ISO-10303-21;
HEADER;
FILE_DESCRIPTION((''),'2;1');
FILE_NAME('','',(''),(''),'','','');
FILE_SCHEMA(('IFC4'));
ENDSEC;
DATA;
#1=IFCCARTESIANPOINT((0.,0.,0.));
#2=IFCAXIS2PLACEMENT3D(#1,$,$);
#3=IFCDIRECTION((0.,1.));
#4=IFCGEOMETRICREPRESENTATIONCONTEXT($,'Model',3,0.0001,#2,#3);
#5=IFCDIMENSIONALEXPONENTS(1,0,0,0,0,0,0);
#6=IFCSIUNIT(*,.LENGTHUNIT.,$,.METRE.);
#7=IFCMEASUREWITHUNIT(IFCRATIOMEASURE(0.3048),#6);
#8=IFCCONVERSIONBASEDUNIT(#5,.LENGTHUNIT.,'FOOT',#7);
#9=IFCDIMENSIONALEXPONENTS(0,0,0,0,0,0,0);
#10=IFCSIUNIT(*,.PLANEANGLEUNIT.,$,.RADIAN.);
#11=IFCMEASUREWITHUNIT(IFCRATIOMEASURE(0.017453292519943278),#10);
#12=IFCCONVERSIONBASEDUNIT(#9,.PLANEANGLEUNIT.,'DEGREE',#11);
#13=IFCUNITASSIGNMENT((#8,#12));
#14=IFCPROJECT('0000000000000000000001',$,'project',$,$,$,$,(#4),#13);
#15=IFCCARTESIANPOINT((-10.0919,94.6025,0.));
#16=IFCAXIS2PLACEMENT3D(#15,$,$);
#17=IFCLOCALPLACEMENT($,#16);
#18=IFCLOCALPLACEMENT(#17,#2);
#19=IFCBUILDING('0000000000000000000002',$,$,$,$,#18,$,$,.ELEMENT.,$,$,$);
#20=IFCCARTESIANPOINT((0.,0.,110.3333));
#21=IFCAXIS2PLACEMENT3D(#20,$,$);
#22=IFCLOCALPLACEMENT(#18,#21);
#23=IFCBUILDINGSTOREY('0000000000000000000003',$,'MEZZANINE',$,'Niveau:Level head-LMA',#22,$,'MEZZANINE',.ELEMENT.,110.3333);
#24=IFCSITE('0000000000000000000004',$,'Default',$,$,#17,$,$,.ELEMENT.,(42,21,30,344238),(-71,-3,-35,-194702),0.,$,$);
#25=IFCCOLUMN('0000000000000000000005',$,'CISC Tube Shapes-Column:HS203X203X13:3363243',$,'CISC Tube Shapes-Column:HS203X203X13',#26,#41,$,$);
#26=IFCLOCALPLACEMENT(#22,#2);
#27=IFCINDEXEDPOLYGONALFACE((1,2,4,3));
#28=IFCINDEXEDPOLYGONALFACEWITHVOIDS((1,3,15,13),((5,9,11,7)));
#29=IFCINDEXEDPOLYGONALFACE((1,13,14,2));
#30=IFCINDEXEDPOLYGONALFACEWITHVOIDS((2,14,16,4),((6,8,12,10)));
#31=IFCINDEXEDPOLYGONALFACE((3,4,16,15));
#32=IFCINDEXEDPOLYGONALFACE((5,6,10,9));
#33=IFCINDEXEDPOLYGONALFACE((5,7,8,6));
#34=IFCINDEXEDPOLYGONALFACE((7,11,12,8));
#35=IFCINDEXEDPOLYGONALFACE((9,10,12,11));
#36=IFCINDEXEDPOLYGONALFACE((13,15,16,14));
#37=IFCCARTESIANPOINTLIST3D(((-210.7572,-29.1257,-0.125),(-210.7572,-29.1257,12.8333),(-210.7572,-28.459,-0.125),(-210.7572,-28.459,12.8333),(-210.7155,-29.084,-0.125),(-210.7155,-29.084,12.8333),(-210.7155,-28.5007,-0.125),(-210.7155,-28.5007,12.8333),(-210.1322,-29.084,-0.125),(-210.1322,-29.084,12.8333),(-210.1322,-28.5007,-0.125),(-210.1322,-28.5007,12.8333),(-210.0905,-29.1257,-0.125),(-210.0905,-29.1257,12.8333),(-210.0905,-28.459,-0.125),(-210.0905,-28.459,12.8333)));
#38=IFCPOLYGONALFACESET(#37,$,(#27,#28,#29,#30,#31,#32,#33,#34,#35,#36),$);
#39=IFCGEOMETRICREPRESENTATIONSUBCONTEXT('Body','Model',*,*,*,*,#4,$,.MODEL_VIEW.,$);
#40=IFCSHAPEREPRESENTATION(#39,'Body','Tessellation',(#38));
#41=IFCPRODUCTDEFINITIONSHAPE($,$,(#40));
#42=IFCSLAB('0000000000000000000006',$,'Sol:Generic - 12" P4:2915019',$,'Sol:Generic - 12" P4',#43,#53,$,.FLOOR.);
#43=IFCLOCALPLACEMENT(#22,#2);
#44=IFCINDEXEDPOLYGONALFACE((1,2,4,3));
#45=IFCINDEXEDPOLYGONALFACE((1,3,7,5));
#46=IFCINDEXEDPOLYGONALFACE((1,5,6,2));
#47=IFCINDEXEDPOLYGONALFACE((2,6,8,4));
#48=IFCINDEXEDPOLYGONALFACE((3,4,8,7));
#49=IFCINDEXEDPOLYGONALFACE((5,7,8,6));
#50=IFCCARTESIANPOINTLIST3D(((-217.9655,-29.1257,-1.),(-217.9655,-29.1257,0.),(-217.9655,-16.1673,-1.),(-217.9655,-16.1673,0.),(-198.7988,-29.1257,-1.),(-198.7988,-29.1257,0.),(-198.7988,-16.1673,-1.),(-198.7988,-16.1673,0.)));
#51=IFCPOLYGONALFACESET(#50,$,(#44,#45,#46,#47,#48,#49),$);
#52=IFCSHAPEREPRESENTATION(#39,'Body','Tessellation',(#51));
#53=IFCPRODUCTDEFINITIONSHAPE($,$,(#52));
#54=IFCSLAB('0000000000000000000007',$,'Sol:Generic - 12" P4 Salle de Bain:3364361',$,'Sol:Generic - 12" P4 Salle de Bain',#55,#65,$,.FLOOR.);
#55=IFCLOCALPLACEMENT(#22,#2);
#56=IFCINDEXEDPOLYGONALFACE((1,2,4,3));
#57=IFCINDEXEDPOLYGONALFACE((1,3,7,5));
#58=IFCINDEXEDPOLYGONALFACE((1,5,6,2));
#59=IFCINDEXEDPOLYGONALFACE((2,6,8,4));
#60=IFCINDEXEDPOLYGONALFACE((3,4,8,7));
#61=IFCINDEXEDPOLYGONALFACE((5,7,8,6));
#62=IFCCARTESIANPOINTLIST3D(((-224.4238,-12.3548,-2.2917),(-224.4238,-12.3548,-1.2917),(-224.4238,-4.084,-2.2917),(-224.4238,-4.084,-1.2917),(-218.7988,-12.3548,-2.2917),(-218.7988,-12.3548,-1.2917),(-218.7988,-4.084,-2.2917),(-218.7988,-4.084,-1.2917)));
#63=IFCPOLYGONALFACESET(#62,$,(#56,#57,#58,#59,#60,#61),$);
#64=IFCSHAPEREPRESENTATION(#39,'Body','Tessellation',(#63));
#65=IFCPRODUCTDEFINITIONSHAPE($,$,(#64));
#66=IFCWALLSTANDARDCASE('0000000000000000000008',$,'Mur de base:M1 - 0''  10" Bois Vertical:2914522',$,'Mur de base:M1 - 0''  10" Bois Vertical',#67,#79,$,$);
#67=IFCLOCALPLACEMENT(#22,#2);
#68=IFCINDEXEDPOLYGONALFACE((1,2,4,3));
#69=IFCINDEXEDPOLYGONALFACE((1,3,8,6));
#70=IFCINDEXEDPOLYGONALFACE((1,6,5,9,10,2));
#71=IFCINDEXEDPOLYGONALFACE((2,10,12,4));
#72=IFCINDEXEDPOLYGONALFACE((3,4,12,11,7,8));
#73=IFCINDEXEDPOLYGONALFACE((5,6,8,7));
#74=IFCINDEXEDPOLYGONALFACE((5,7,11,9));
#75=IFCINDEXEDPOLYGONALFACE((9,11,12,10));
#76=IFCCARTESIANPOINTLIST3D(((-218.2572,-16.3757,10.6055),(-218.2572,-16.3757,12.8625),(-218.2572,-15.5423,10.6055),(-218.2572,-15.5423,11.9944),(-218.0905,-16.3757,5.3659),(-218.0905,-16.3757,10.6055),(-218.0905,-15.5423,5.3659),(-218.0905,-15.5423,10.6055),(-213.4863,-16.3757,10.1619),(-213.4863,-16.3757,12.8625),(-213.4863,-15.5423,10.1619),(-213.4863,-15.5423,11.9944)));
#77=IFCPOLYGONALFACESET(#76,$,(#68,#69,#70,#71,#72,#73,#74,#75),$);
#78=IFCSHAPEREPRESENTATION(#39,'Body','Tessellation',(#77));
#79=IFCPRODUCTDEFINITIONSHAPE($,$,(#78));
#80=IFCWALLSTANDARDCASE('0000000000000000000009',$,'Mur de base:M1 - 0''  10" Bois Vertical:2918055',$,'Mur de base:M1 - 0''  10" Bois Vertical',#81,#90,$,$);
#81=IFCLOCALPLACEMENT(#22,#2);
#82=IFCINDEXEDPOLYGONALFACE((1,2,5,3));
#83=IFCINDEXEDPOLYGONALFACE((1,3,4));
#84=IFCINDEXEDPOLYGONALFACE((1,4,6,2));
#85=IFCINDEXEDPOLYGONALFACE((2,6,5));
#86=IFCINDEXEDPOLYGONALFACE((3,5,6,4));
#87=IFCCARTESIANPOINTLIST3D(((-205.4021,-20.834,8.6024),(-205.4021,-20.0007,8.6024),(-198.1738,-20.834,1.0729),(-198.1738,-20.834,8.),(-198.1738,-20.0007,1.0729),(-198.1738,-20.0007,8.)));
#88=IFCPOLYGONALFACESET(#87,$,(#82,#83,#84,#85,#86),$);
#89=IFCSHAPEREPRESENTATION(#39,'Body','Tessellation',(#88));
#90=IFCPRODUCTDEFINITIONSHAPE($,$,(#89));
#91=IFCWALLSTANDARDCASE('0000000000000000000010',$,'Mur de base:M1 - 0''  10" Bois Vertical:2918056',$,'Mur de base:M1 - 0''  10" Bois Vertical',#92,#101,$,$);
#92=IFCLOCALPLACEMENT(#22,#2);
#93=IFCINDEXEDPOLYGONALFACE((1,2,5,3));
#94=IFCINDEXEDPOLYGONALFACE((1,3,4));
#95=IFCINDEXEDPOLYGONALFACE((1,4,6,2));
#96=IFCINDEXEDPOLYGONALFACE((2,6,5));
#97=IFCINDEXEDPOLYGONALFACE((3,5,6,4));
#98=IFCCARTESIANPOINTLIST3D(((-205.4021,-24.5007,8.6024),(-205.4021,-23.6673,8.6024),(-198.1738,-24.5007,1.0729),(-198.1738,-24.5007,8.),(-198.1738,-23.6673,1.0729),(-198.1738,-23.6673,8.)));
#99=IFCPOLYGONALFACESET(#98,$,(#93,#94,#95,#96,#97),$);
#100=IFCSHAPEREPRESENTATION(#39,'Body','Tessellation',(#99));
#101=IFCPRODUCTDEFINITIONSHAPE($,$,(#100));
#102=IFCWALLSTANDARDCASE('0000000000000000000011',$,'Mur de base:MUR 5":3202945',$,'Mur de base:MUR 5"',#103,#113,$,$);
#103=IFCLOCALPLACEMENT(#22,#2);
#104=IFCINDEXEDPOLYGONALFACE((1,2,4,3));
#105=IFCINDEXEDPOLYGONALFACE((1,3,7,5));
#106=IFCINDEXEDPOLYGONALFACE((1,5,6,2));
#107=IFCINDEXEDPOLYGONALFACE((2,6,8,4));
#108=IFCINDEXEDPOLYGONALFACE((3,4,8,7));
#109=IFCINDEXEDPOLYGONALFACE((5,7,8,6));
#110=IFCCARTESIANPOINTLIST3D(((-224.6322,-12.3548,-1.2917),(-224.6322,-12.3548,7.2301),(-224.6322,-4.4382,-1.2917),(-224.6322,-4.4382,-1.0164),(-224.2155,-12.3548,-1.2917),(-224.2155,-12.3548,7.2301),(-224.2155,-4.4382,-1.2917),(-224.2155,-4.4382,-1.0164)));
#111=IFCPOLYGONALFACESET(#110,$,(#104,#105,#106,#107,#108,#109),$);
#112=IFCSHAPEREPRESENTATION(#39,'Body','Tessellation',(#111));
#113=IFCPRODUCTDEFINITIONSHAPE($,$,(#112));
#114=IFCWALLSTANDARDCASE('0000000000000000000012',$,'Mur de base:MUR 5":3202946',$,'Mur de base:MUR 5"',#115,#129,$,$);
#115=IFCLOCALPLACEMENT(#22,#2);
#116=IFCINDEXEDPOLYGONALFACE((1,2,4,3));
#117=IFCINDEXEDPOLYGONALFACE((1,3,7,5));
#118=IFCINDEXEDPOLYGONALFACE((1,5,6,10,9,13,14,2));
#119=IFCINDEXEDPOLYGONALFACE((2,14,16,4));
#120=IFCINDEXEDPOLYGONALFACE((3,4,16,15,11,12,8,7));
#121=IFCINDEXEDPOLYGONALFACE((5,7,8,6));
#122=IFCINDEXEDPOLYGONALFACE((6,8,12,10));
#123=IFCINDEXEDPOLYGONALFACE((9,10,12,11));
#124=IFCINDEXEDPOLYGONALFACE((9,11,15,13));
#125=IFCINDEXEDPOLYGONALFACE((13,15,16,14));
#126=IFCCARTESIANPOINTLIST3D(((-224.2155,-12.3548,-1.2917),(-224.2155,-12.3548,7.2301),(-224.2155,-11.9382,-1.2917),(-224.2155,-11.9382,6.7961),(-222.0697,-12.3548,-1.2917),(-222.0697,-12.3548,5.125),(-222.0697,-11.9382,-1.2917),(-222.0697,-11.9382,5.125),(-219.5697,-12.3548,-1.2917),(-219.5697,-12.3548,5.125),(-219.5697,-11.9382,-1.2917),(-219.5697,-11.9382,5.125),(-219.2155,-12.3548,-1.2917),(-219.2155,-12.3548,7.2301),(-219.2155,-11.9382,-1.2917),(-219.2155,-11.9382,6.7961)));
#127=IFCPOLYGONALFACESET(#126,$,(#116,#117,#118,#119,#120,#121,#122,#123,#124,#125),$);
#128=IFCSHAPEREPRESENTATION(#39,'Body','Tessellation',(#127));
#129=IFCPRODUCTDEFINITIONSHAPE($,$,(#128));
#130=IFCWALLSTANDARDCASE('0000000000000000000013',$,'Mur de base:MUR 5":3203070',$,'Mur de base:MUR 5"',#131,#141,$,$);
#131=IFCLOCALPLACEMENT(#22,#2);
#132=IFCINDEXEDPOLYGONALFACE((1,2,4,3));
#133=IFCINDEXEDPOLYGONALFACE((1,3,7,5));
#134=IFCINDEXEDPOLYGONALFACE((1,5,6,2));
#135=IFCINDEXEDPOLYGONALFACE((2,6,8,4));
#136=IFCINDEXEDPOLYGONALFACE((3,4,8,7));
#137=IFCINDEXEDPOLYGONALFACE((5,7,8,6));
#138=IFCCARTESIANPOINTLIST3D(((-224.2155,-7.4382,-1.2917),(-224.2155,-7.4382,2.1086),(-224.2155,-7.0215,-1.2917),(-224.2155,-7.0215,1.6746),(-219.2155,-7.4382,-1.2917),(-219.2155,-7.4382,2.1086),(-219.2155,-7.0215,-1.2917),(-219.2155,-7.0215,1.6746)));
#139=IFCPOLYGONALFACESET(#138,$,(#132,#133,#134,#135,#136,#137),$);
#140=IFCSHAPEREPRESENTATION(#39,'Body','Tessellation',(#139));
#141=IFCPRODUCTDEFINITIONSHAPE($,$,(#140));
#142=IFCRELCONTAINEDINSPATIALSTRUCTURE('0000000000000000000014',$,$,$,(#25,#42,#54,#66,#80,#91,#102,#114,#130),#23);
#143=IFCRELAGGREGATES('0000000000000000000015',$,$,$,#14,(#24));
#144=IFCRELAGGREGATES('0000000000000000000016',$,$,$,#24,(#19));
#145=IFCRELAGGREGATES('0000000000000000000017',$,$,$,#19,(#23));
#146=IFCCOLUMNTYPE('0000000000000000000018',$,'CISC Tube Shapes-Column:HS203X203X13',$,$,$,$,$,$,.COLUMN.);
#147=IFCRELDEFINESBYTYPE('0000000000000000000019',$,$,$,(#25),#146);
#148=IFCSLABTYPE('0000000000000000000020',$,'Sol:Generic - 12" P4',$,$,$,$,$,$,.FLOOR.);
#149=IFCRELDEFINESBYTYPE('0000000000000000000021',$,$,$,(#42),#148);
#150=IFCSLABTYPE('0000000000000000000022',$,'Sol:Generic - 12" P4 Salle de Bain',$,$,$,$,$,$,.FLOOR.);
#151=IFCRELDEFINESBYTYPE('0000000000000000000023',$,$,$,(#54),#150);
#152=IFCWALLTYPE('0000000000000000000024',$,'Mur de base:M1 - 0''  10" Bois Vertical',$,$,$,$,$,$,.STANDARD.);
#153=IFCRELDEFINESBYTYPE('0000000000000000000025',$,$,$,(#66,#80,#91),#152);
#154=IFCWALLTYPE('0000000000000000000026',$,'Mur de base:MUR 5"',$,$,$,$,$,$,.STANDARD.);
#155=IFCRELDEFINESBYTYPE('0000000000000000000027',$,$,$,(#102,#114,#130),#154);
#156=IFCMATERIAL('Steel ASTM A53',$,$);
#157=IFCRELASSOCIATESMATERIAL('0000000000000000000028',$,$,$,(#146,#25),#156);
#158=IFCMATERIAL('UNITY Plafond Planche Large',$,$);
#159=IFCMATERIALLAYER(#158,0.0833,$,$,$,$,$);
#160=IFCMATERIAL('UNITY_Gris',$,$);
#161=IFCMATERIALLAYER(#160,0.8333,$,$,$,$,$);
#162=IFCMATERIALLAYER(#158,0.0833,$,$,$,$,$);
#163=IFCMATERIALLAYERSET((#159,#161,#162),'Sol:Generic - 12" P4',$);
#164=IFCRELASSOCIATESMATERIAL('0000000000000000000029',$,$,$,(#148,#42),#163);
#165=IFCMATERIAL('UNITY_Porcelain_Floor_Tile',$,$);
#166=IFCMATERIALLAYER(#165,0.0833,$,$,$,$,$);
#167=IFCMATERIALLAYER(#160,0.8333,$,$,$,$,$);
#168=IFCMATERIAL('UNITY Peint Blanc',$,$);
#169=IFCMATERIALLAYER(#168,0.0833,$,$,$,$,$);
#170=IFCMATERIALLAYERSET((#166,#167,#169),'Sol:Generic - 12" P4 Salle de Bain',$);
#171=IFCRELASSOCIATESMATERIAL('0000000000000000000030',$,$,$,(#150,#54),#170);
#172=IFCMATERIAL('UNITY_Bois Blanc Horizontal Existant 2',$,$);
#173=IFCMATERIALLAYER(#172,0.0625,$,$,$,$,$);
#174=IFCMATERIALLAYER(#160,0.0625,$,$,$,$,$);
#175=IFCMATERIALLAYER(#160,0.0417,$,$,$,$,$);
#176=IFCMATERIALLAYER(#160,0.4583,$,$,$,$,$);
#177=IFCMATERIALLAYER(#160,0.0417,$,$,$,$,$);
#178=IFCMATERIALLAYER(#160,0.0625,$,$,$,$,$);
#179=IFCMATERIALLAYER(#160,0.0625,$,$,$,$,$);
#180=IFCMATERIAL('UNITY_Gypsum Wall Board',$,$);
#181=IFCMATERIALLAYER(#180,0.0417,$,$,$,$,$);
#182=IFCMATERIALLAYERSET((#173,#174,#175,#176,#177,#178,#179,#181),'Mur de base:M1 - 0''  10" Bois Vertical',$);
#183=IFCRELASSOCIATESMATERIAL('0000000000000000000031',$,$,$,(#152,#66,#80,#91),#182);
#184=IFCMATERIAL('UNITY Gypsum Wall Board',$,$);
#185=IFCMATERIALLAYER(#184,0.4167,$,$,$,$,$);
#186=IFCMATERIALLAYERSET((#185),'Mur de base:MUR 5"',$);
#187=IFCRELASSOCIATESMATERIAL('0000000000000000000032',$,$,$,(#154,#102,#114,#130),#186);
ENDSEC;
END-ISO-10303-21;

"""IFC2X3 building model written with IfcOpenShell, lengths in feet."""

from ifc_helpers import new_model, entity, si_unit, converted_unit, direction, frame, frame_2d, origin, origin_2d_with_axis, place, context, subcontext, project, spatial, polyline, rectangle, outline, extrude, clip, bounded_halfspace, source, transform, mapped, material, layer, layer_set, layer_usage, type_object, type_shapes, element, save


model = new_model("IFC2X3")

# Units and contexts
model_context = context("Model", 3, precision=0.0001, world=origin(), true_north=direction((0.0, 1.0)))
body_context = subcontext(model_context, "Body", "Model", "MODEL_VIEW")
ifc_project = project(units=[converted_unit("LENGTHUNIT", "FOOT", entity("IfcRatioMeasure", 0.3048), si_unit("LENGTHUNIT", "METRE"), dimensions=[1, 0, 0, 0, 0, 0, 0]), converted_unit("PLANEANGLEUNIT", "DEGREE", entity("IfcRatioMeasure", 0.017453292519943278), si_unit("PLANEANGLEUNIT", "RADIAN"), dimensions=[0, 0, 0, 0, 0, 0, 0])], contexts=[model_context])

# Site, building, storey
site_placement = place(None, frame((-10.0919, 94.6025, 0.0)))
site = spatial("IfcSite", under=ifc_project, at=site_placement, Name="Default", CompositionType="ELEMENT", RefLatitude=(42, 21, 30, 344238), RefLongitude=(-71, -3, -35, -194702), RefElevation=0.0)
building_placement = place(site_placement, origin())
building = spatial("IfcBuilding", under=site, at=building_placement, CompositionType="ELEMENT")
storey_placement = place(building_placement, frame((0.0, 0.0, 110.3333)))
storey = spatial("IfcBuildingStorey", under=building, at=storey_placement, Name="MEZZANINE", ObjectType="Niveau:Level head-LMA", LongName="MEZZANINE", CompositionType="ELEMENT", Elevation=110.3333)

# Column
ifc_material_1 = material(Name="Steel ASTM A53")
column_type = type_object("IfcColumnType", Name="CISC Tube Shapes-Column:HS203X203X13", PredefinedType="COLUMN", material=ifc_material_1)
shared_shape_1 = source(origin(), body_context, "Body", "SweptSolid", [
    extrude(outline(polyline([(-0.3333, -0.3333), (0.3333, -0.3333), (0.3333, 0.3333), (-0.3333, 0.3333), (-0.3333, -0.3333)]), holes=[polyline([(-0.2917, -0.2917), (-0.2917, 0.2917), (0.2917, 0.2917), (0.2917, -0.2917), (-0.2917, -0.2917)])]), frame((0.0, 0.0, 110.2083), z_axis=(0.0, 0.0, 1.0), x_axis=(-1.0, 0.0, 0.0)), (0.0, 0.0, 1.0), 12.9583),
])
type_shapes(column_type, [shared_shape_1])
column_placement = place(storey_placement, frame((-210.4238, -28.7923, -110.3333)))
element("IfcColumn", 1, at=column_placement, inside=storey, type_object=column_type, material=ifc_material_1, Name="CISC Tube Shapes-Column:HS203X203X13:3363243", ObjectType="CISC Tube Shapes-Column:HS203X203X13", context=body_context, shape_type="MappedRepresentation", body=[
    mapped(shared_shape_1, transform((0.0, 0.0, 0.0), scale=1.0)),
])

# Slabs
ifc_material_2 = material(Name="UNITY Plafond Planche Large")
ifc_layer_1 = layer(ifc_material_2, 0.0833)
ifc_material_3 = material(Name="UNITY_Gris")
ifc_layer_2 = layer(ifc_material_3, 0.8333)
ifc_layer_3 = layer(ifc_material_2, 0.0833)
ifc_layer_set_1 = layer_set([ifc_layer_1, ifc_layer_2, ifc_layer_3], Name="Sol:Generic - 12\" P4")
ifc_layer_usage_1 = layer_usage(ifc_layer_set_1, "AXIS3", "POSITIVE", 0.0)
slab_type_1 = type_object("IfcSlabType", Name="Sol:Generic - 12\" P4", PredefinedType="FLOOR", material=ifc_layer_set_1)
slab_1_placement = place(storey_placement, origin())
element("IfcSlab", 2, at=slab_1_placement, inside=storey, type_object=slab_type_1, material=ifc_layer_usage_1, Name="Sol:Generic - 12\" P4:2915019", ObjectType="Sol:Generic - 12\" P4", PredefinedType="FLOOR", context=body_context, shape_type="SweptSolid", body=[
    extrude(rectangle(XDim=12.9583, YDim=19.1666, at=origin_2d_with_axis()), frame((-208.3822, -22.6465, 0.0), z_axis=(0.0, 0.0, -1.0), x_axis=(0.0, 1.0, 0.0)), (0.0, 0.0, 1.0), 1.0),
])
ifc_material_4 = material(Name="UNITY Peint Blanc")
ifc_material_5 = material(Name="UNITY_Porcelain_Floor_Tile")
ifc_layer_4 = layer(ifc_material_5, 0.0833)
ifc_layer_5 = layer(ifc_material_3, 0.8333)
ifc_layer_6 = layer(ifc_material_4, 0.0833)
ifc_layer_set_2 = layer_set([ifc_layer_4, ifc_layer_5, ifc_layer_6], Name="Sol:Generic - 12\" P4 Salle de Bain")
ifc_layer_usage_2 = layer_usage(ifc_layer_set_2, "AXIS3", "POSITIVE", 0.0)
slab_type_2 = type_object("IfcSlabType", Name="Sol:Generic - 12\" P4 Salle de Bain", PredefinedType="FLOOR", material=ifc_layer_set_2)
slab_2_placement = place(storey_placement, origin())
element("IfcSlab", 3, at=slab_2_placement, inside=storey, type_object=slab_type_2, material=ifc_layer_usage_2, Name="Sol:Generic - 12\" P4 Salle de Bain:3364361", ObjectType="Sol:Generic - 12\" P4 Salle de Bain", PredefinedType="FLOOR", context=body_context, shape_type="SweptSolid", body=[
    extrude(rectangle(XDim=8.2708, YDim=5.625, at=frame_2d((0.0, 0.0), x_axis=(1.0, 0.0))), frame((-221.6113, -8.2194, -1.2917), z_axis=(0.0, 0.0, -1.0), x_axis=(0.0, 1.0, 0.0)), (0.0, 0.0, 1.0), 1.0),
])

# Shared definitions
ifc_material_6 = material(Name="UNITY_Bois Blanc Horizontal Existant 2")
ifc_material_7 = material(Name="UNITY_Gypsum Wall Board")

# Wall
ifc_layer_7 = layer(ifc_material_6, 0.0625)
ifc_layer_8 = layer(ifc_material_3, 0.0625)
ifc_layer_9 = layer(ifc_material_3, 0.0417)
ifc_layer_10 = layer(ifc_material_3, 0.4583)
ifc_layer_11 = layer(ifc_material_3, 0.0417)
ifc_layer_12 = layer(ifc_material_3, 0.0625)
ifc_layer_13 = layer(ifc_material_3, 0.0625)
ifc_layer_14 = layer(ifc_material_7, 0.0417)
ifc_layer_set_3 = layer_set([ifc_layer_7, ifc_layer_8, ifc_layer_9, ifc_layer_10, ifc_layer_11, ifc_layer_12, ifc_layer_13, ifc_layer_14], Name="Mur de base:M1 - 0'  10\" Bois Vertical")
ifc_layer_usage_3 = layer_usage(ifc_layer_set_3, "AXIS2", "NEGATIVE", 0.4167)
wall_type_1 = type_object("IfcWallType", Name="Mur de base:M1 - 0'  10\" Bois Vertical", PredefinedType="STANDARD", material=ifc_layer_set_3)
wall_1_placement = place(storey_placement, frame((-218.2572, -15.959, 5.3659)))
element("IfcWallStandardCase", 4, at=wall_1_placement, inside=storey, type_object=wall_type_1, material=ifc_layer_usage_3, Name="Mur de base:M1 - 0'  10\" Bois Vertical:2914522", ObjectType="Mur de base:M1 - 0'  10\" Bois Vertical", context=body_context, shape_type="Clipping", body=[
    clip(clip(clip(clip(extrude(rectangle(XDim=4.7708, YDim=0.8333, at=frame_2d((2.3854, 0.0), x_axis=(-1.0, 0.0))), origin(), (0.0, 0.0, 1.0), 7.4966), bounded_halfspace(frame((0.0, -0.4167, 7.4966), z_axis=(0.0, 0.721387, 0.692532), x_axis=(-1.0, 0.0, 0.0)), False, frame((0.0, -0.4167, 7.4966)), polyline([(0.0, 0.0), (4.7708, 0.0), (4.7708, 0.8333), (0.0, 0.8333), (0.0, 0.0)]))), bounded_halfspace(frame((4.7708, 0.4167, 4.796), z_axis=(-0.721387, 0.0, 0.692532), x_axis=(0.0, -1.0, 0.0)), True, frame((4.7708, 0.4167, 4.796)), polyline([(0.0, 0.0), (-4.6042, 0.0), (-4.6042, -0.8333), (0.0, -0.8333), (0.0, 0.0)]))), bounded_halfspace(frame((0.1667, 0.4167, 5.2396)), True, frame((0.1667, 0.4167, 5.2396)), polyline([(0.0, 0.0), (-0.1667, 0.0), (-0.1667, -0.8333), (0.0, -0.8333), (0.0, 0.0)]))), bounded_halfspace(frame((0.1667, -0.4167, 5.2396), z_axis=(1.0, 0.0, 0.0), x_axis=(0.0, 0.0, -1.0)), True, frame((0.1667, -0.4167, 5.2396), z_axis=(1.0, 0.0, 0.0), x_axis=(0.0, 0.0, -1.0)), polyline([(0.0, 0.0), (5.2396, 0.0), (5.2396, 0.8333), (0.0, 0.8333), (0.0, 0.0)]))),
])

# Walls, openings
ifc_layer_usage_4 = layer_usage(ifc_layer_set_3, "AXIS2", "POSITIVE", -0.4167)
wall_2_placement = place(storey_placement, frame((-198.1738, -20.4173, 1.0729), z_axis=(0.0, 0.0, 1.0), x_axis=(-1.0, 0.0, 0.0)))
wall_2 = element("IfcWallStandardCase", 5, at=wall_2_placement, inside=storey, type_object=wall_type_1, material=ifc_layer_usage_4, Name="Mur de base:M1 - 0'  10\" Bois Vertical:2918055", ObjectType="Mur de base:M1 - 0'  10\" Bois Vertical", context=body_context, shape_type="Clipping", body=[
    clip(clip(extrude(rectangle(XDim=7.2283, YDim=0.8333, at=frame_2d((3.6141, 0.0), x_axis=(-1.0, 0.0))), origin(), (0.0, 0.0, 1.0), 7.5294), bounded_halfspace(frame((0.0, -0.4167, 6.9271), z_axis=(-0.083045, 0.0, 0.996546), x_axis=(0.0, -1.0, 0.0)), False, frame((0.0, -0.4167, 6.9271)), polyline([(0.0, 0.0), (7.2283, 0.0), (7.2283, 0.8333), (0.8333, 0.8333), (0.0, 0.8333), (0.0, 0.0)]))), bounded_halfspace(frame((7.2283, -0.4167, 7.5294), z_axis=(-0.721387, 0.0, 0.692532), x_axis=(0.0, -1.0, 0.0)), True, frame((7.2283, -0.4167, 7.5294)), polyline([(0.0, 0.0), (0.0, 0.8333), (-7.2283, 0.8333), (-7.2283, 0.0), (0.0, 0.0)]))),
])
opening_1_placement = place(wall_2_placement, origin())
element("IfcOpeningElement", 6, at=opening_1_placement, cuts=wall_2, ObjectType="Opening", context=body_context, shape_type="SweptSolid", body=[
    extrude(rectangle(XDim=6.5833, YDim=0.8333, at=frame_2d((0.0, 0.0), x_axis=(0.0, 1.0))), frame((0.4167, 0.4167, 3.6354), z_axis=(0.0, 1.0, 0.0), x_axis=(1.0, 0.0, 0.0)), (0.0, 0.0, 1.0), 2.8333),
])
ifc_layer_usage_5 = layer_usage(ifc_layer_set_3, "AXIS2", "NEGATIVE", 0.4167)
wall_3_placement = place(storey_placement, frame((-198.1738, -24.084, 1.0729), z_axis=(0.0, 0.0, 1.0), x_axis=(-1.0, 0.0, 0.0)))
wall_3 = element("IfcWallStandardCase", 7, at=wall_3_placement, inside=storey, type_object=wall_type_1, material=ifc_layer_usage_5, Name="Mur de base:M1 - 0'  10\" Bois Vertical:2918056", ObjectType="Mur de base:M1 - 0'  10\" Bois Vertical", context=body_context, shape_type="Clipping", body=[
    clip(clip(extrude(rectangle(XDim=7.2283, YDim=0.8333, at=frame_2d((3.6141, 0.0), x_axis=(-1.0, 0.0))), origin(), (0.0, 0.0, 1.0), 7.5294), bounded_halfspace(frame((0.0, 0.4167, 6.9271), z_axis=(-0.083045, 0.0, 0.996546), x_axis=(0.0, -1.0, 0.0)), False, frame((0.0, 0.4167, 6.9271)), polyline([(0.0, 0.0), (0.0, -0.8333), (0.8333, -0.8333), (7.2283, -0.8333), (7.2283, 0.0), (0.0, 0.0)]))), bounded_halfspace(frame((7.2283, -0.4167, 7.5294), z_axis=(-0.721387, 0.0, 0.692532), x_axis=(0.0, -1.0, 0.0)), True, frame((7.2283, -0.4167, 7.5294)), polyline([(0.0, 0.0), (0.0, 0.8333), (-7.2283, 0.8333), (-7.2283, 0.0), (0.0, 0.0)]))),
])
opening_2_placement = place(wall_3_placement, origin())
element("IfcOpeningElement", 8, at=opening_2_placement, cuts=wall_3, ObjectType="Opening", context=body_context, shape_type="SweptSolid", body=[
    extrude(rectangle(XDim=6.5833, YDim=0.8333, at=frame_2d((0.0, 0.0), x_axis=(0.0, 1.0))), frame((0.4167, -3.25, 3.6354), z_axis=(0.0, 1.0, 0.0), x_axis=(1.0, 0.0, 0.0)), (0.0, 0.0, 1.0), 2.8333),
])

# Wall
ifc_material_8 = material(Name="UNITY Gypsum Wall Board")
ifc_layer_15 = layer(ifc_material_8, 0.4167)
ifc_layer_set_4 = layer_set([ifc_layer_15], Name="Mur de base:MUR 5\"")
ifc_layer_usage_6 = layer_usage(ifc_layer_set_4, "AXIS2", "NEGATIVE", 0.2083)
wall_type_2 = type_object("IfcWallType", Name="Mur de base:MUR 5\"", PredefinedType="STANDARD", material=ifc_layer_set_4)
wall_4_placement = place(storey_placement, frame((-224.4238, -12.3548, -1.2917), z_axis=(0.0, 0.0, 1.0), x_axis=(0.0, 1.0, 0.0)))
element("IfcWallStandardCase", 9, at=wall_4_placement, inside=storey, type_object=wall_type_2, material=ifc_layer_usage_6, Name="Mur de base:MUR 5\":3202945", ObjectType="Mur de base:MUR 5\"", context=body_context, shape_type="Clipping", body=[
    clip(extrude(rectangle(XDim=7.9167, YDim=0.4167, at=frame_2d((3.9583, 0.0), x_axis=(-1.0, 0.0))), origin(), (0.0, 0.0, 1.0), 8.5218), bounded_halfspace(frame((0.0, -0.2083, 8.5218), z_axis=(0.721387, 0.0, 0.692532), x_axis=(0.0, 1.0, 0.0)), False, frame((0.0, -0.2083, 8.5218)), polyline([(0.0, 0.0), (0.4167, 0.0), (4.9167, 0.0), (5.3333, 0.0), (7.9167, 0.0), (7.9167, 0.4167), (0.0, 0.4167), (0.0, 0.0)]))),
])

# Wall, opening
ifc_layer_usage_7 = layer_usage(ifc_layer_set_4, "AXIS2", "POSITIVE", -0.2083)
wall_5_placement = place(storey_placement, frame((-224.2155, -12.1465, -1.2917)))
wall_5 = element("IfcWallStandardCase", 10, at=wall_5_placement, inside=storey, type_object=wall_type_2, material=ifc_layer_usage_7, Name="Mur de base:MUR 5\":3202946", ObjectType="Mur de base:MUR 5\"", context=body_context, shape_type="Clipping", body=[
    clip(extrude(rectangle(XDim=5.0, YDim=0.4167, at=frame_2d((2.5, 0.0), x_axis=(-1.0, 0.0))), origin(), (0.0, 0.0, 1.0), 8.5218), bounded_halfspace(frame((0.0, -0.2083, 8.5218), z_axis=(0.0, 0.721387, 0.692532), x_axis=(-1.0, 0.0, 0.0)), False, frame((0.0, -0.2083, 8.5218)), polyline([(0.0, 0.0), (5.0, 0.0), (5.0, 0.4167), (0.0, 0.4167), (0.0, 0.0)]))),
])
opening_3_placement = place(wall_5_placement, frame((224.2155, 12.1465, 1.2917)))
element("IfcOpeningElement", 11, at=opening_3_placement, cuts=wall_5, ObjectType="Opening", context=body_context, shape_type="SweptSolid", body=[
    extrude(rectangle(XDim=6.4167, YDim=2.5, at=frame_2d((0.0, 0.0), x_axis=(0.0, 1.0))), frame((-220.8197, -17.3548, 1.9167), z_axis=(0.0, 1.0, 0.0), x_axis=(-1.0, 0.0, 0.0)), (0.0, 0.0, 1.0), 10.0),
])

# Wall
ifc_layer_usage_8 = layer_usage(ifc_layer_set_4, "AXIS2", "POSITIVE", -0.2083)
wall_6_placement = place(storey_placement, frame((-224.2155, -7.2298, -1.2917)))
element("IfcWallStandardCase", 12, at=wall_6_placement, inside=storey, type_object=wall_type_2, material=ifc_layer_usage_8, Name="Mur de base:MUR 5\":3203070", ObjectType="Mur de base:MUR 5\"", context=body_context, shape_type="Clipping", body=[
    clip(extrude(rectangle(XDim=5.0, YDim=0.4167, at=frame_2d((2.5, 0.0), x_axis=(-1.0, 0.0))), origin(), (0.0, 0.0, 1.0), 3.4003), bounded_halfspace(frame((0.0, -0.2083, 3.4003), z_axis=(0.0, 0.721387, 0.692532), x_axis=(-1.0, 0.0, 0.0)), False, frame((0.0, -0.2083, 3.4003)), polyline([(0.0, 0.0), (5.0, 0.0), (5.0, 0.4167), (0.0, 0.4167), (0.0, 0.0)]))),
])

save(model, "model.ifc")
